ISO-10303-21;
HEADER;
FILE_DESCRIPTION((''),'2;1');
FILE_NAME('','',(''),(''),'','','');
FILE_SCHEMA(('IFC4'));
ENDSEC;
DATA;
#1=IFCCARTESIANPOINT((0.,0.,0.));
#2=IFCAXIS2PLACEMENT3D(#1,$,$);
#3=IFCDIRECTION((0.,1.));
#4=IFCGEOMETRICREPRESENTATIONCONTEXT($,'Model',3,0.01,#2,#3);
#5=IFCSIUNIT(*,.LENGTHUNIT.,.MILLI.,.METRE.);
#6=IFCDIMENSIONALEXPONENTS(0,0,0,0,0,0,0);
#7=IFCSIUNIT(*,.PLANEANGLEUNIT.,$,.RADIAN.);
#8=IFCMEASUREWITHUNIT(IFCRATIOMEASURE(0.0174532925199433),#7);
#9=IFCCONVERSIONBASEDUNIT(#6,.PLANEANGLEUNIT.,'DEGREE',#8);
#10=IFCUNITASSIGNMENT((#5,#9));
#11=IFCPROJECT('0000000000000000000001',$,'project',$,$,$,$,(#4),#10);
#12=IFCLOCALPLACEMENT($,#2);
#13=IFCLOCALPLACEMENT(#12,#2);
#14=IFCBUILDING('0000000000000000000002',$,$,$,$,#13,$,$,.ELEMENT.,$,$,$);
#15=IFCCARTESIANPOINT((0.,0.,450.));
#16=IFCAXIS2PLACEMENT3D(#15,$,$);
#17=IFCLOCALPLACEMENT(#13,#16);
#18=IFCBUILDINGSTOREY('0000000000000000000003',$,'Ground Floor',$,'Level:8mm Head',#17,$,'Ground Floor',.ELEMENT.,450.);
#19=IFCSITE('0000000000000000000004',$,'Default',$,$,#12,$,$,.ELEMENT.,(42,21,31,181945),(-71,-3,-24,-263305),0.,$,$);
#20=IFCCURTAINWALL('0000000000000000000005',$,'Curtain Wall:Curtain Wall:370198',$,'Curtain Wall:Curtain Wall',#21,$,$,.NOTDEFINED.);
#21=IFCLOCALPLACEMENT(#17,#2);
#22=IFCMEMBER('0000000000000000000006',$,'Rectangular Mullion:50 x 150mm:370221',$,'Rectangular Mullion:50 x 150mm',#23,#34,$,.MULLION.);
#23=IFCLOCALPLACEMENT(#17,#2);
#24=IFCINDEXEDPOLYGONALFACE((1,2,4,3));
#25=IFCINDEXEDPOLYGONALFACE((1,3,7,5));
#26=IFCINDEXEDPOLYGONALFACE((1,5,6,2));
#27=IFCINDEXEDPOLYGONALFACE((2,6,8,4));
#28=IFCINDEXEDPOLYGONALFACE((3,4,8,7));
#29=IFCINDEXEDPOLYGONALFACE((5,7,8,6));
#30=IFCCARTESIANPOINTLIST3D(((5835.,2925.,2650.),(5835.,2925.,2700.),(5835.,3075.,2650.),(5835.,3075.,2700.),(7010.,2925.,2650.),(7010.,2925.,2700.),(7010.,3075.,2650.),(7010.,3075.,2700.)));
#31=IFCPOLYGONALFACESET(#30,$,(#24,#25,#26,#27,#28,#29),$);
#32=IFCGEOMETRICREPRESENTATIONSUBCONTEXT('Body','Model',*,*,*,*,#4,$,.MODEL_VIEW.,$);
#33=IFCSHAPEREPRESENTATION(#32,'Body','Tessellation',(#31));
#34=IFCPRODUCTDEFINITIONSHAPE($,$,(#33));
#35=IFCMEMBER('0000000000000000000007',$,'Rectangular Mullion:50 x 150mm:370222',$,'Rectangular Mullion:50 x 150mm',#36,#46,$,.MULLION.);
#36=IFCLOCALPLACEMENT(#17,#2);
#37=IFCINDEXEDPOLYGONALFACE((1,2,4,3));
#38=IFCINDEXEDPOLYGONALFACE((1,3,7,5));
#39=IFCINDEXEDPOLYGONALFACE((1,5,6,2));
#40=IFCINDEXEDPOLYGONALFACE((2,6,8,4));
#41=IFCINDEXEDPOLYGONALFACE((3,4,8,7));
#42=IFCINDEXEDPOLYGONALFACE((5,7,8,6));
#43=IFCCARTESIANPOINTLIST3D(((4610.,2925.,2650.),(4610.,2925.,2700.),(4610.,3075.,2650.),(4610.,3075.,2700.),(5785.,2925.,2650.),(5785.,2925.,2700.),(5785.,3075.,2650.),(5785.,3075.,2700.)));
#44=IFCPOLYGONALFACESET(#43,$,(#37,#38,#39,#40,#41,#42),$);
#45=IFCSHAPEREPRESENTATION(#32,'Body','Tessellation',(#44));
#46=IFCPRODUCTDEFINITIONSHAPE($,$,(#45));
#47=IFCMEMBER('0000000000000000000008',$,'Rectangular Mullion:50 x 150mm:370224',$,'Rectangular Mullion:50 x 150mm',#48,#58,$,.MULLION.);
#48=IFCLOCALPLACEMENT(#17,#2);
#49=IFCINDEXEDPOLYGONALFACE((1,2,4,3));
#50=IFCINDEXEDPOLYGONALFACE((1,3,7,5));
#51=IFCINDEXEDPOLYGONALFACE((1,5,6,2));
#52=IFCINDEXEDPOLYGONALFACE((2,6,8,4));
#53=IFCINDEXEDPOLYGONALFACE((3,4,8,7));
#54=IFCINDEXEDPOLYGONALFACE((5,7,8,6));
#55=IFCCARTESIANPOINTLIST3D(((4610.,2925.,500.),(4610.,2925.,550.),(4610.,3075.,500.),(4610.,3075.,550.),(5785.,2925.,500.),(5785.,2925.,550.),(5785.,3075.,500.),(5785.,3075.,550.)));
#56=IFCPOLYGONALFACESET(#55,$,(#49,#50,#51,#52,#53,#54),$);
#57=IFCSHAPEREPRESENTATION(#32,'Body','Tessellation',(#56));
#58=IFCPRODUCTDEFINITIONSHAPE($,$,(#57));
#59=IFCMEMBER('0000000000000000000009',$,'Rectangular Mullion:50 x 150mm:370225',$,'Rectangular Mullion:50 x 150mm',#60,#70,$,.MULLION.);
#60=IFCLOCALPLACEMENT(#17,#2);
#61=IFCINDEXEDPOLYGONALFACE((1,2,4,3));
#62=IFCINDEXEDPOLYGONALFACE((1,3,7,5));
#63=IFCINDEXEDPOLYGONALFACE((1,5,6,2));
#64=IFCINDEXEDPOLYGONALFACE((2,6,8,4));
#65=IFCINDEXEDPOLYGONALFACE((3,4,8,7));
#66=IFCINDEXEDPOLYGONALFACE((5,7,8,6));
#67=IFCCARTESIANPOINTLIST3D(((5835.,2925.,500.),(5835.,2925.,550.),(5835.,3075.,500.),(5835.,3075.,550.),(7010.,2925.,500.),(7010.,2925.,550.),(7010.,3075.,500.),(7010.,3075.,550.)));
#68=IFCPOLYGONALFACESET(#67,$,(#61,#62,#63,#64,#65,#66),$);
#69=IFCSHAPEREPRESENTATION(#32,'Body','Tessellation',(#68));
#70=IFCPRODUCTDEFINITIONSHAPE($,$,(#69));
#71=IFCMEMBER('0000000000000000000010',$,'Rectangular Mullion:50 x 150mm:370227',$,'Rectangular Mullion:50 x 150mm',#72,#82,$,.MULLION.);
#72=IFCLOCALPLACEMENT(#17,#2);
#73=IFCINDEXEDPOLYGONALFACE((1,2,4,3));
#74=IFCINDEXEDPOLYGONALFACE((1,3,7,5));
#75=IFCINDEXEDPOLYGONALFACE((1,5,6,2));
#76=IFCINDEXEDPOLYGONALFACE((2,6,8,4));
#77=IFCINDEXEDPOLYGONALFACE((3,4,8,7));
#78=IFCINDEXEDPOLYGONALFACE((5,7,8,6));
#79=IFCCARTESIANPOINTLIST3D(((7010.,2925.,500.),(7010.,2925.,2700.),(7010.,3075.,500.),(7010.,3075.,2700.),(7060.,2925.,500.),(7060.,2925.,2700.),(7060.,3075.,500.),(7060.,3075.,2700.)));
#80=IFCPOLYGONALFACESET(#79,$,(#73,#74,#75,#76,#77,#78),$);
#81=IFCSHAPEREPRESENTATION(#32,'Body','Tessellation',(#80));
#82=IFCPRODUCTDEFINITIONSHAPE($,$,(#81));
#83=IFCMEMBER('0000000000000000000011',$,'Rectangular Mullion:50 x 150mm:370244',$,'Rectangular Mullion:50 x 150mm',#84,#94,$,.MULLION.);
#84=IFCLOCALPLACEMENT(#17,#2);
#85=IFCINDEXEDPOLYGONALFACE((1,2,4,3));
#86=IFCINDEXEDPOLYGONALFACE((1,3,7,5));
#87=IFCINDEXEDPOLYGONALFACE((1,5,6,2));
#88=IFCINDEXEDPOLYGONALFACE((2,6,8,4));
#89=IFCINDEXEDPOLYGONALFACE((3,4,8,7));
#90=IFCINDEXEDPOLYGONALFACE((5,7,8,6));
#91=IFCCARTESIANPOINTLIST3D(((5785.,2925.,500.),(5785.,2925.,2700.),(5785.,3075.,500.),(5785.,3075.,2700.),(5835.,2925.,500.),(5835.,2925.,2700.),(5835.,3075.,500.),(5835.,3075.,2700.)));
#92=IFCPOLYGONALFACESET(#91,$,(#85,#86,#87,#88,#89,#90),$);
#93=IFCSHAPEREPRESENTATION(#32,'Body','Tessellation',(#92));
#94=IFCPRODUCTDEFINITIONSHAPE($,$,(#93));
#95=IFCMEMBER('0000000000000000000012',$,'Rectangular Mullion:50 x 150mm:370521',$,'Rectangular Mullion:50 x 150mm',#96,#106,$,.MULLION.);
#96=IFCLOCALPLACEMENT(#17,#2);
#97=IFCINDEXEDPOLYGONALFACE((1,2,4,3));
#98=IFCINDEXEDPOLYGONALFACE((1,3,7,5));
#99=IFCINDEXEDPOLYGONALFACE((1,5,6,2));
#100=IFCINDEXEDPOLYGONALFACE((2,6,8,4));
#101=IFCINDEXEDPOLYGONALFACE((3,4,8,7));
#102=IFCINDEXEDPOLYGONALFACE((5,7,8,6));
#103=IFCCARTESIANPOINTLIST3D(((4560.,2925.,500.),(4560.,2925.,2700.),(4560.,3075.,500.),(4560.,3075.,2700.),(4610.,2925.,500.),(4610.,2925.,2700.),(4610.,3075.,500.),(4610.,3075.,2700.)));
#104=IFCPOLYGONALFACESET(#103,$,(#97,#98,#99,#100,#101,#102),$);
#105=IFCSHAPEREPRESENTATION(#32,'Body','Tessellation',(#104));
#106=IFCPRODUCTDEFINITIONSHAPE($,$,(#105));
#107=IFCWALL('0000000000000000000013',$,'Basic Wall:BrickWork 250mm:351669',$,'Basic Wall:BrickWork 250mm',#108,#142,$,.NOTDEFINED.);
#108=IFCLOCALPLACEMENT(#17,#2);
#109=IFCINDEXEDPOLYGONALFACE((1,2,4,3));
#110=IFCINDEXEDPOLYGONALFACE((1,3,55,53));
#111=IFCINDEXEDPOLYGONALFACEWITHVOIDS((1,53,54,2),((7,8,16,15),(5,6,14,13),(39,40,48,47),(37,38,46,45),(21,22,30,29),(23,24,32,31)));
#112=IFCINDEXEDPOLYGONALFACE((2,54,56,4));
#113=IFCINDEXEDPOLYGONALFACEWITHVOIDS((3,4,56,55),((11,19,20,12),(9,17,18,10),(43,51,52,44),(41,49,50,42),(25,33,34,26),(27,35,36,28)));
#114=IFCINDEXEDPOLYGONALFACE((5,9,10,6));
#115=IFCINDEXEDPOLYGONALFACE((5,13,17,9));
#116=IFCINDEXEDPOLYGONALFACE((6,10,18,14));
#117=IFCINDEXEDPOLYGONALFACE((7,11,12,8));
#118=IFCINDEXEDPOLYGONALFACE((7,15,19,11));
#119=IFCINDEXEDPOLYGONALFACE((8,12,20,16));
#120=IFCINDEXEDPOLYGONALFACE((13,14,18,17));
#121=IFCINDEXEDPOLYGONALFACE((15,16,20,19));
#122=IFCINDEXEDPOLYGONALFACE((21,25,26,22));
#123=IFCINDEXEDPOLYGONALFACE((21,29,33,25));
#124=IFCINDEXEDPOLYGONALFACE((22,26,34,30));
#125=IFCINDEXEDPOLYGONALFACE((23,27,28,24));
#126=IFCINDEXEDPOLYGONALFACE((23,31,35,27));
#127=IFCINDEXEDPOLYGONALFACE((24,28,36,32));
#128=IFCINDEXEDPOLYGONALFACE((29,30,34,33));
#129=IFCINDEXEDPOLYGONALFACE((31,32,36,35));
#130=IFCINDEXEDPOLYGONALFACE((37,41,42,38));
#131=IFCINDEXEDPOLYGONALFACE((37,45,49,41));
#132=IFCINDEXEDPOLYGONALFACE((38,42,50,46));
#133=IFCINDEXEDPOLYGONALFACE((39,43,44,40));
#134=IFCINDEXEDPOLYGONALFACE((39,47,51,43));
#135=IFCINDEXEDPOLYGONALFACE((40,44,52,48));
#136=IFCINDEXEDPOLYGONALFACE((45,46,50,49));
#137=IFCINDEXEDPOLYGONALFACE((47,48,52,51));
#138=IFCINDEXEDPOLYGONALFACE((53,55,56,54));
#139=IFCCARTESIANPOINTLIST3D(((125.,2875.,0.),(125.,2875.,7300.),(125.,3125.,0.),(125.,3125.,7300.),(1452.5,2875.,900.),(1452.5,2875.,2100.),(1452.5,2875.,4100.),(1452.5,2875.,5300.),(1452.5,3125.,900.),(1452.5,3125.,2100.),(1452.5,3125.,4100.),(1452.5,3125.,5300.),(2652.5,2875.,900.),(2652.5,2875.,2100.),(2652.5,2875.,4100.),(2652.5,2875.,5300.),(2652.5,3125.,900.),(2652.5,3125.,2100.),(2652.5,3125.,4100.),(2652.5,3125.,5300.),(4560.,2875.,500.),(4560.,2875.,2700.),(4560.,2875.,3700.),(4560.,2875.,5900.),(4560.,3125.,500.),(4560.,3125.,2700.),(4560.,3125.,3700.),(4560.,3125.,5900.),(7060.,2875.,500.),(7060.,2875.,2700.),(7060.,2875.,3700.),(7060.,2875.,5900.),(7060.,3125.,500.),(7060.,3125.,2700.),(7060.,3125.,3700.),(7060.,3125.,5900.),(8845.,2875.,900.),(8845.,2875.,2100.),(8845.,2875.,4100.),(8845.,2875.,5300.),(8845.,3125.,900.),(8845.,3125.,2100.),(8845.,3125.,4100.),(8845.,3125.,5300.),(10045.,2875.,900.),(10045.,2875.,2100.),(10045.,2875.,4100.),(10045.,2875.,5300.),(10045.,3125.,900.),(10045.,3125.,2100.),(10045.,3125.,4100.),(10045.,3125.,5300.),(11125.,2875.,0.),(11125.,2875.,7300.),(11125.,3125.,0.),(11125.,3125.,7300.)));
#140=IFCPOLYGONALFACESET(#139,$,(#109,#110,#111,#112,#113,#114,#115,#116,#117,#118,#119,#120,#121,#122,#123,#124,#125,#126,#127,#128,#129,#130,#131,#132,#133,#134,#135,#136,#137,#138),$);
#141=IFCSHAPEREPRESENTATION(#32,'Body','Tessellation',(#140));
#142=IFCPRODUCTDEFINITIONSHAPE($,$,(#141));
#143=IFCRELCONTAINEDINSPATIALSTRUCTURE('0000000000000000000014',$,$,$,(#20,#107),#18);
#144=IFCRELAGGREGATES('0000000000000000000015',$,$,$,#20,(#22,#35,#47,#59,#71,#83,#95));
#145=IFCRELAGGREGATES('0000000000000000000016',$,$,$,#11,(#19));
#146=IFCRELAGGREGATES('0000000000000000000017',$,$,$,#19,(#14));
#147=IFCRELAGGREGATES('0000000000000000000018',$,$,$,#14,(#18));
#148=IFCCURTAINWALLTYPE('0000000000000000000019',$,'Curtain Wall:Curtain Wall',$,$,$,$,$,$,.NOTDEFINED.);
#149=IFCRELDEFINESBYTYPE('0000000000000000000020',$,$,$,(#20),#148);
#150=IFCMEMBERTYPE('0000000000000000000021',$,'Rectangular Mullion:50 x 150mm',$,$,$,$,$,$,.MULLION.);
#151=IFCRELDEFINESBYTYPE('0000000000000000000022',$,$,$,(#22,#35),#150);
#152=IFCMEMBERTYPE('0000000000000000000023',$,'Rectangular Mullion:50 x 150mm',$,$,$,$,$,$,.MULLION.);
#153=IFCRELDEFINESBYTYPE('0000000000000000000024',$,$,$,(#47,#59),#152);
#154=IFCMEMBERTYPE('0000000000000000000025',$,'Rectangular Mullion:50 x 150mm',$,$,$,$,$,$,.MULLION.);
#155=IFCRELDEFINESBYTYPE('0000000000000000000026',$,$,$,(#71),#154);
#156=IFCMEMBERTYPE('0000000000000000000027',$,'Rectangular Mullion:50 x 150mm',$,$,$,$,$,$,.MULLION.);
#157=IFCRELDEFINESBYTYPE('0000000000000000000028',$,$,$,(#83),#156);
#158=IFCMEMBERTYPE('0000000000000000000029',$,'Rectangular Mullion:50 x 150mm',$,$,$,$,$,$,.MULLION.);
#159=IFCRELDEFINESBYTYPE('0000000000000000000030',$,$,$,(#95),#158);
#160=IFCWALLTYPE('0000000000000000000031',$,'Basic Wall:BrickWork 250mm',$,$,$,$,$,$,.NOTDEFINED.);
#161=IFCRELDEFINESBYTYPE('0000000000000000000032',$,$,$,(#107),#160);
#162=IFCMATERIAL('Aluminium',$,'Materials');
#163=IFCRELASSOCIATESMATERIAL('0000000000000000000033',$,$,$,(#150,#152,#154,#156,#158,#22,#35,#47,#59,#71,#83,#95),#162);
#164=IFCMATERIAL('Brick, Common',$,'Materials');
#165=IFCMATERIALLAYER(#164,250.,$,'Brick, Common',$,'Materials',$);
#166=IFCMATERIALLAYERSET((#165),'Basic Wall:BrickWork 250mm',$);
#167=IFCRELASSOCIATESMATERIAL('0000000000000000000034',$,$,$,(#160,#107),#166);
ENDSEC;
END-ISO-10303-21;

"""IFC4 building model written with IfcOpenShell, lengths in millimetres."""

from ifc_helpers import new_model, entity, si_unit, converted_unit, direction, frame, frame_2d, origin, origin_2d_with_axis, place, context, subcontext, project, spatial, rectangle, extrude, source, transform, mapped, material, layer, layer_set, layer_usage, material_profile, profile_set, profile_usage, type_object, type_shapes, element, aggregate, save


model = new_model("IFC4")

# Units and contexts
model_context = context("Model", 3, precision=0.01, world=origin(), true_north=direction((0.0, 1.0)))
body_context = subcontext(model_context, "Body", "Model", "MODEL_VIEW")
ifc_project = project(units=[si_unit("LENGTHUNIT", "METRE", prefix="MILLI"), converted_unit("PLANEANGLEUNIT", "DEGREE", entity("IfcRatioMeasure", 0.0174532925199433), si_unit("PLANEANGLEUNIT", "RADIAN"), dimensions=[0, 0, 0, 0, 0, 0, 0])], contexts=[model_context])

# Site, building, storey
site_placement = place(None, origin())
site = spatial("IfcSite", under=ifc_project, at=site_placement, Name="Default", CompositionType="ELEMENT", RefLatitude=(42, 21, 31, 181945), RefLongitude=(-71, -3, -24, -263305), RefElevation=0.0)
building_placement = place(site_placement, origin())
building = spatial("IfcBuilding", under=site, at=building_placement, CompositionType="ELEMENT")
storey_placement = place(building_placement, frame((0.0, 0.0, 450.0)))
storey = spatial("IfcBuildingStorey", under=building, at=storey_placement, Name="Ground Floor", ObjectType="Level:8mm Head", LongName="Ground Floor", CompositionType="ELEMENT", Elevation=450.0)

# Curtain wall, members
curtain_wall_type = type_object("IfcCurtainWallType", Name="Curtain Wall:Curtain Wall", PredefinedType="NOTDEFINED")
curtain_wall_placement = place(storey_placement, frame((0.0, 0.0, -450.0)))
curtain_wall = element("IfcCurtainWall", 1, at=curtain_wall_placement, inside=storey, type_object=curtain_wall_type, Name="Curtain Wall:Curtain Wall:370198", ObjectType="Curtain Wall:Curtain Wall", PredefinedType="NOTDEFINED")
ifc_material_1 = material(Name="Aluminium", Category="Materials")
ifc_material_profile = material_profile(ifc_material_1, rectangle(XDim=150.0, YDim=50.0, at=origin_2d_with_axis()), Name="50 x 150mm")
ifc_profile_set = profile_set([ifc_material_profile], Name="50 x 150mm")
ifc_profile_usage_1 = profile_usage(ifc_profile_set)
member_type_1 = type_object("IfcMemberType", Name="Rectangular Mullion:50 x 150mm", PredefinedType="MULLION", material=ifc_profile_set)
shared_shape_1 = source(origin(), body_context, "Body", "SweptSolid", [
    extrude(rectangle(XDim=150.0, YDim=50.0, at=origin_2d_with_axis()), frame((-25.0, 0.0, -1175.0), z_axis=(0.0, 0.0, 1.0), x_axis=(0.0, -1.0, 0.0)), (0.0, 0.0, 1.0), 1175.0),
])
type_shapes(member_type_1, [shared_shape_1])
member_1_placement = place(storey_placement, frame((7010.0, 3000.0, 2700.0), z_axis=(1.0, 0.0, 0.0), x_axis=(0.0, 0.0, 1.0)))
member_1 = element("IfcMember", 2, at=member_1_placement, type_object=member_type_1, material=ifc_profile_usage_1, Name="Rectangular Mullion:50 x 150mm:370221", ObjectType="Rectangular Mullion:50 x 150mm", PredefinedType="MULLION", context=body_context, shape_type="MappedRepresentation", body=[
    mapped(shared_shape_1, transform((0.0, 0.0, 0.0), scale=1.0)),
])
ifc_profile_usage_2 = profile_usage(ifc_profile_set)
member_2_placement = place(storey_placement, frame((5785.0, 3000.0, 2700.0), z_axis=(1.0, 0.0, 0.0), x_axis=(0.0, 0.0, 1.0)))
member_2 = element("IfcMember", 3, at=member_2_placement, type_object=member_type_1, material=ifc_profile_usage_2, Name="Rectangular Mullion:50 x 150mm:370222", ObjectType="Rectangular Mullion:50 x 150mm", PredefinedType="MULLION", context=body_context, shape_type="MappedRepresentation", body=[
    mapped(shared_shape_1, transform((0.0, 0.0, 0.0), scale=1.0)),
])
ifc_profile_usage_3 = profile_usage(ifc_profile_set)
member_type_2 = type_object("IfcMemberType", Name="Rectangular Mullion:50 x 150mm", PredefinedType="MULLION", material=ifc_profile_set)
shared_shape_2 = source(origin(), body_context, "Body", "SweptSolid", [
    extrude(rectangle(XDim=150.0, YDim=50.0, at=origin_2d_with_axis()), frame((-25.0, 0.0, -1175.0), z_axis=(0.0, 0.0, 1.0), x_axis=(0.0, -1.0, 0.0)), (0.0, 0.0, 1.0), 1175.0),
])
type_shapes(member_type_2, [shared_shape_2])
member_3_placement = place(storey_placement, frame((4610.0, 3000.0, 500.0), z_axis=(-1.0, 0.0, 0.0), x_axis=(0.0, 0.0, -1.0)))
member_3 = element("IfcMember", 4, at=member_3_placement, type_object=member_type_2, material=ifc_profile_usage_3, Name="Rectangular Mullion:50 x 150mm:370224", ObjectType="Rectangular Mullion:50 x 150mm", PredefinedType="MULLION", context=body_context, shape_type="MappedRepresentation", body=[
    mapped(shared_shape_2, transform((0.0, 0.0, 0.0), scale=1.0)),
])
ifc_profile_usage_4 = profile_usage(ifc_profile_set)
member_4_placement = place(storey_placement, frame((5835.0, 3000.0, 500.0), z_axis=(-1.0, 0.0, 0.0), x_axis=(0.0, 0.0, -1.0)))
member_4 = element("IfcMember", 5, at=member_4_placement, type_object=member_type_2, material=ifc_profile_usage_4, Name="Rectangular Mullion:50 x 150mm:370225", ObjectType="Rectangular Mullion:50 x 150mm", PredefinedType="MULLION", context=body_context, shape_type="MappedRepresentation", body=[
    mapped(shared_shape_2, transform((0.0, 0.0, 0.0), scale=1.0)),
])
ifc_profile_usage_5 = profile_usage(ifc_profile_set)
member_type_3 = type_object("IfcMemberType", Name="Rectangular Mullion:50 x 150mm", PredefinedType="MULLION", material=ifc_profile_set)
shared_shape_3 = source(origin(), body_context, "Body", "SweptSolid", [
    extrude(rectangle(XDim=150.0, YDim=50.0, at=origin_2d_with_axis()), frame((-25.0, 0.0, -2200.0), z_axis=(0.0, 0.0, 1.0), x_axis=(0.0, -1.0, 0.0)), (0.0, 0.0, 1.0), 2200.0),
])
type_shapes(member_type_3, [shared_shape_3])
member_5_placement = place(storey_placement, frame((7060.0, 3000.0, 500.0), z_axis=(0.0, 0.0, -1.0), x_axis=(1.0, 0.0, 0.0)))
member_5 = element("IfcMember", 6, at=member_5_placement, type_object=member_type_3, material=ifc_profile_usage_5, Name="Rectangular Mullion:50 x 150mm:370227", ObjectType="Rectangular Mullion:50 x 150mm", PredefinedType="MULLION", context=body_context, shape_type="MappedRepresentation", body=[
    mapped(shared_shape_3, transform((0.0, 0.0, 0.0), scale=1.0)),
])
ifc_profile_usage_6 = profile_usage(ifc_profile_set)
member_type_4 = type_object("IfcMemberType", Name="Rectangular Mullion:50 x 150mm", PredefinedType="MULLION", material=ifc_profile_set)
shared_shape_4 = source(origin(), body_context, "Body", "SweptSolid", [
    extrude(rectangle(XDim=150.0, YDim=50.0, at=origin_2d_with_axis()), frame((0.0, 0.0, -2200.0), z_axis=(0.0, 0.0, 1.0), x_axis=(0.0, -1.0, 0.0)), (0.0, 0.0, 1.0), 2200.0),
])
type_shapes(member_type_4, [shared_shape_4])
member_6_placement = place(storey_placement, frame((5810.0, 3000.0, 500.0), z_axis=(0.0, 0.0, -1.0), x_axis=(1.0, 0.0, 0.0)))
member_6 = element("IfcMember", 7, at=member_6_placement, type_object=member_type_4, material=ifc_profile_usage_6, Name="Rectangular Mullion:50 x 150mm:370244", ObjectType="Rectangular Mullion:50 x 150mm", PredefinedType="MULLION", context=body_context, shape_type="MappedRepresentation", body=[
    mapped(shared_shape_4, transform((0.0, 0.0, 0.0), scale=1.0)),
])
ifc_profile_usage_7 = profile_usage(ifc_profile_set)
member_type_5 = type_object("IfcMemberType", Name="Rectangular Mullion:50 x 150mm", PredefinedType="MULLION", material=ifc_profile_set)
shared_shape_5 = source(origin(), body_context, "Body", "SweptSolid", [
    extrude(rectangle(XDim=150.0, YDim=50.0, at=origin_2d_with_axis()), frame((-25.0, 0.0, -2200.0), z_axis=(0.0, 0.0, 1.0), x_axis=(0.0, -1.0, 0.0)), (0.0, 0.0, 1.0), 2200.0),
])
type_shapes(member_type_5, [shared_shape_5])
member_7_placement = place(storey_placement, frame((4560.0, 3000.0, 2700.0), z_axis=(0.0, 0.0, 1.0), x_axis=(-1.0, 0.0, 0.0)))
member_7 = element("IfcMember", 8, at=member_7_placement, type_object=member_type_5, material=ifc_profile_usage_7, Name="Rectangular Mullion:50 x 150mm:370521", ObjectType="Rectangular Mullion:50 x 150mm", PredefinedType="MULLION", context=body_context, shape_type="MappedRepresentation", body=[
    mapped(shared_shape_5, transform((0.0, 0.0, 0.0), scale=1.0)),
])

aggregate(curtain_wall, [member_1, member_2, member_3, member_4, member_5, member_6, member_7])

# Wall, openings
ifc_material_2 = material(Name="Brick, Common", Category="Materials")
ifc_layer_1 = layer(ifc_material_2, 250.0, Name="Brick, Common", Category="Materials")
ifc_layer_set_1 = layer_set([ifc_layer_1], Name="Basic Wall:BrickWork 250mm")
ifc_layer_usage_1 = layer_usage(ifc_layer_set_1, "AXIS2", "POSITIVE", -125.0)
wall_type = type_object("IfcWallType", Name="Basic Wall:BrickWork 250mm", PredefinedType="NOTDEFINED", material=ifc_layer_set_1)
wall_placement = place(storey_placement, frame((125.0, 3000.0, 0.0)))
wall = element("IfcWall", 9, at=wall_placement, inside=storey, type_object=wall_type, material=ifc_layer_usage_1, Name="Basic Wall:BrickWork 250mm:351669", ObjectType="Basic Wall:BrickWork 250mm", PredefinedType="NOTDEFINED", context=body_context, shape_type="SweptSolid", body=[
    extrude(rectangle(XDim=11000.0, YDim=250.0, at=frame_2d((5500.0, 0.0), x_axis=(-1.0, 0.0))), origin(), (0.0, 0.0, 1.0), 7300.0),
])
opening_1_placement = place(wall_placement, frame((4435.0, -277.4, 500.0)))
element("IfcOpeningElement", 10, at=opening_1_placement, cuts=wall, ObjectType="Opening", PredefinedType="OPENING", context=body_context, shape_type="SweptSolid", body=[
    extrude(rectangle(XDim=2200.0, YDim=2500.0, at=frame_2d((0.0, 0.0), x_axis=(1.0, 0.0))), frame((1250.0, 0.0, 1100.0), z_axis=(0.0, 1.0, 0.0), x_axis=(0.0, 0.0, 1.0)), (0.0, 0.0, 1.0), 554.8),
])
opening_2_placement = place(wall_placement, frame((4435.0, -277.4, 3700.0)))
element("IfcOpeningElement", 11, at=opening_2_placement, cuts=wall, ObjectType="Opening", PredefinedType="OPENING", context=body_context, shape_type="SweptSolid", body=[
    extrude(rectangle(XDim=2200.0, YDim=2500.0, at=frame_2d((0.0, 0.0), x_axis=(1.0, 0.0))), frame((1250.0, 0.0, 1100.0), z_axis=(0.0, 1.0, 0.0), x_axis=(0.0, 0.0, 1.0)), (0.0, 0.0, 1.0), 554.8),
])
opening_3_placement = place(wall_placement, frame((1327.5, -125.0, 900.0)))
element("IfcOpeningElement", 12, at=opening_3_placement, cuts=wall, ObjectType="Opening", PredefinedType="OPENING", context=body_context, shape_type="SweptSolid", body=[
    extrude(rectangle(XDim=1200.0, YDim=1200.0, at=frame_2d((600.0, 600.0), x_axis=(-1.0, 0.0))), frame((0.0, 0.0, 0.0), z_axis=(0.0, 1.0, 0.0), x_axis=(0.0, 0.0, 1.0)), (0.0, 0.0, 1.0), 250.0),
])
opening_4_placement = place(wall_placement, frame((8720.0, -125.0, 900.0)))
element("IfcOpeningElement", 13, at=opening_4_placement, cuts=wall, ObjectType="Opening", PredefinedType="OPENING", context=body_context, shape_type="SweptSolid", body=[
    extrude(rectangle(XDim=1200.0, YDim=1200.0, at=frame_2d((600.0, 600.0), x_axis=(-1.0, 0.0))), frame((0.0, 0.0, 0.0), z_axis=(0.0, 1.0, 0.0), x_axis=(0.0, 0.0, 1.0)), (0.0, 0.0, 1.0), 250.0),
])
opening_5_placement = place(wall_placement, frame((1327.5, -125.0, 4100.0)))
element("IfcOpeningElement", 14, at=opening_5_placement, cuts=wall, ObjectType="Opening", PredefinedType="OPENING", context=body_context, shape_type="SweptSolid", body=[
    extrude(rectangle(XDim=1200.0, YDim=1200.0, at=frame_2d((600.0, 600.0), x_axis=(-1.0, 0.0))), frame((0.0, 0.0, 0.0), z_axis=(0.0, 1.0, 0.0), x_axis=(0.0, 0.0, 1.0)), (0.0, 0.0, 1.0), 250.0),
])
opening_6_placement = place(wall_placement, frame((8720.0, -125.0, 4100.0)))
element("IfcOpeningElement", 15, at=opening_6_placement, cuts=wall, ObjectType="Opening", PredefinedType="OPENING", context=body_context, shape_type="SweptSolid", body=[
    extrude(rectangle(XDim=1200.0, YDim=1200.0, at=frame_2d((600.0, 600.0), x_axis=(-1.0, 0.0))), frame((0.0, 0.0, 0.0), z_axis=(0.0, 1.0, 0.0), x_axis=(0.0, 0.0, 1.0)), (0.0, 0.0, 1.0), 250.0),
])

save(model, "model.ifc")
